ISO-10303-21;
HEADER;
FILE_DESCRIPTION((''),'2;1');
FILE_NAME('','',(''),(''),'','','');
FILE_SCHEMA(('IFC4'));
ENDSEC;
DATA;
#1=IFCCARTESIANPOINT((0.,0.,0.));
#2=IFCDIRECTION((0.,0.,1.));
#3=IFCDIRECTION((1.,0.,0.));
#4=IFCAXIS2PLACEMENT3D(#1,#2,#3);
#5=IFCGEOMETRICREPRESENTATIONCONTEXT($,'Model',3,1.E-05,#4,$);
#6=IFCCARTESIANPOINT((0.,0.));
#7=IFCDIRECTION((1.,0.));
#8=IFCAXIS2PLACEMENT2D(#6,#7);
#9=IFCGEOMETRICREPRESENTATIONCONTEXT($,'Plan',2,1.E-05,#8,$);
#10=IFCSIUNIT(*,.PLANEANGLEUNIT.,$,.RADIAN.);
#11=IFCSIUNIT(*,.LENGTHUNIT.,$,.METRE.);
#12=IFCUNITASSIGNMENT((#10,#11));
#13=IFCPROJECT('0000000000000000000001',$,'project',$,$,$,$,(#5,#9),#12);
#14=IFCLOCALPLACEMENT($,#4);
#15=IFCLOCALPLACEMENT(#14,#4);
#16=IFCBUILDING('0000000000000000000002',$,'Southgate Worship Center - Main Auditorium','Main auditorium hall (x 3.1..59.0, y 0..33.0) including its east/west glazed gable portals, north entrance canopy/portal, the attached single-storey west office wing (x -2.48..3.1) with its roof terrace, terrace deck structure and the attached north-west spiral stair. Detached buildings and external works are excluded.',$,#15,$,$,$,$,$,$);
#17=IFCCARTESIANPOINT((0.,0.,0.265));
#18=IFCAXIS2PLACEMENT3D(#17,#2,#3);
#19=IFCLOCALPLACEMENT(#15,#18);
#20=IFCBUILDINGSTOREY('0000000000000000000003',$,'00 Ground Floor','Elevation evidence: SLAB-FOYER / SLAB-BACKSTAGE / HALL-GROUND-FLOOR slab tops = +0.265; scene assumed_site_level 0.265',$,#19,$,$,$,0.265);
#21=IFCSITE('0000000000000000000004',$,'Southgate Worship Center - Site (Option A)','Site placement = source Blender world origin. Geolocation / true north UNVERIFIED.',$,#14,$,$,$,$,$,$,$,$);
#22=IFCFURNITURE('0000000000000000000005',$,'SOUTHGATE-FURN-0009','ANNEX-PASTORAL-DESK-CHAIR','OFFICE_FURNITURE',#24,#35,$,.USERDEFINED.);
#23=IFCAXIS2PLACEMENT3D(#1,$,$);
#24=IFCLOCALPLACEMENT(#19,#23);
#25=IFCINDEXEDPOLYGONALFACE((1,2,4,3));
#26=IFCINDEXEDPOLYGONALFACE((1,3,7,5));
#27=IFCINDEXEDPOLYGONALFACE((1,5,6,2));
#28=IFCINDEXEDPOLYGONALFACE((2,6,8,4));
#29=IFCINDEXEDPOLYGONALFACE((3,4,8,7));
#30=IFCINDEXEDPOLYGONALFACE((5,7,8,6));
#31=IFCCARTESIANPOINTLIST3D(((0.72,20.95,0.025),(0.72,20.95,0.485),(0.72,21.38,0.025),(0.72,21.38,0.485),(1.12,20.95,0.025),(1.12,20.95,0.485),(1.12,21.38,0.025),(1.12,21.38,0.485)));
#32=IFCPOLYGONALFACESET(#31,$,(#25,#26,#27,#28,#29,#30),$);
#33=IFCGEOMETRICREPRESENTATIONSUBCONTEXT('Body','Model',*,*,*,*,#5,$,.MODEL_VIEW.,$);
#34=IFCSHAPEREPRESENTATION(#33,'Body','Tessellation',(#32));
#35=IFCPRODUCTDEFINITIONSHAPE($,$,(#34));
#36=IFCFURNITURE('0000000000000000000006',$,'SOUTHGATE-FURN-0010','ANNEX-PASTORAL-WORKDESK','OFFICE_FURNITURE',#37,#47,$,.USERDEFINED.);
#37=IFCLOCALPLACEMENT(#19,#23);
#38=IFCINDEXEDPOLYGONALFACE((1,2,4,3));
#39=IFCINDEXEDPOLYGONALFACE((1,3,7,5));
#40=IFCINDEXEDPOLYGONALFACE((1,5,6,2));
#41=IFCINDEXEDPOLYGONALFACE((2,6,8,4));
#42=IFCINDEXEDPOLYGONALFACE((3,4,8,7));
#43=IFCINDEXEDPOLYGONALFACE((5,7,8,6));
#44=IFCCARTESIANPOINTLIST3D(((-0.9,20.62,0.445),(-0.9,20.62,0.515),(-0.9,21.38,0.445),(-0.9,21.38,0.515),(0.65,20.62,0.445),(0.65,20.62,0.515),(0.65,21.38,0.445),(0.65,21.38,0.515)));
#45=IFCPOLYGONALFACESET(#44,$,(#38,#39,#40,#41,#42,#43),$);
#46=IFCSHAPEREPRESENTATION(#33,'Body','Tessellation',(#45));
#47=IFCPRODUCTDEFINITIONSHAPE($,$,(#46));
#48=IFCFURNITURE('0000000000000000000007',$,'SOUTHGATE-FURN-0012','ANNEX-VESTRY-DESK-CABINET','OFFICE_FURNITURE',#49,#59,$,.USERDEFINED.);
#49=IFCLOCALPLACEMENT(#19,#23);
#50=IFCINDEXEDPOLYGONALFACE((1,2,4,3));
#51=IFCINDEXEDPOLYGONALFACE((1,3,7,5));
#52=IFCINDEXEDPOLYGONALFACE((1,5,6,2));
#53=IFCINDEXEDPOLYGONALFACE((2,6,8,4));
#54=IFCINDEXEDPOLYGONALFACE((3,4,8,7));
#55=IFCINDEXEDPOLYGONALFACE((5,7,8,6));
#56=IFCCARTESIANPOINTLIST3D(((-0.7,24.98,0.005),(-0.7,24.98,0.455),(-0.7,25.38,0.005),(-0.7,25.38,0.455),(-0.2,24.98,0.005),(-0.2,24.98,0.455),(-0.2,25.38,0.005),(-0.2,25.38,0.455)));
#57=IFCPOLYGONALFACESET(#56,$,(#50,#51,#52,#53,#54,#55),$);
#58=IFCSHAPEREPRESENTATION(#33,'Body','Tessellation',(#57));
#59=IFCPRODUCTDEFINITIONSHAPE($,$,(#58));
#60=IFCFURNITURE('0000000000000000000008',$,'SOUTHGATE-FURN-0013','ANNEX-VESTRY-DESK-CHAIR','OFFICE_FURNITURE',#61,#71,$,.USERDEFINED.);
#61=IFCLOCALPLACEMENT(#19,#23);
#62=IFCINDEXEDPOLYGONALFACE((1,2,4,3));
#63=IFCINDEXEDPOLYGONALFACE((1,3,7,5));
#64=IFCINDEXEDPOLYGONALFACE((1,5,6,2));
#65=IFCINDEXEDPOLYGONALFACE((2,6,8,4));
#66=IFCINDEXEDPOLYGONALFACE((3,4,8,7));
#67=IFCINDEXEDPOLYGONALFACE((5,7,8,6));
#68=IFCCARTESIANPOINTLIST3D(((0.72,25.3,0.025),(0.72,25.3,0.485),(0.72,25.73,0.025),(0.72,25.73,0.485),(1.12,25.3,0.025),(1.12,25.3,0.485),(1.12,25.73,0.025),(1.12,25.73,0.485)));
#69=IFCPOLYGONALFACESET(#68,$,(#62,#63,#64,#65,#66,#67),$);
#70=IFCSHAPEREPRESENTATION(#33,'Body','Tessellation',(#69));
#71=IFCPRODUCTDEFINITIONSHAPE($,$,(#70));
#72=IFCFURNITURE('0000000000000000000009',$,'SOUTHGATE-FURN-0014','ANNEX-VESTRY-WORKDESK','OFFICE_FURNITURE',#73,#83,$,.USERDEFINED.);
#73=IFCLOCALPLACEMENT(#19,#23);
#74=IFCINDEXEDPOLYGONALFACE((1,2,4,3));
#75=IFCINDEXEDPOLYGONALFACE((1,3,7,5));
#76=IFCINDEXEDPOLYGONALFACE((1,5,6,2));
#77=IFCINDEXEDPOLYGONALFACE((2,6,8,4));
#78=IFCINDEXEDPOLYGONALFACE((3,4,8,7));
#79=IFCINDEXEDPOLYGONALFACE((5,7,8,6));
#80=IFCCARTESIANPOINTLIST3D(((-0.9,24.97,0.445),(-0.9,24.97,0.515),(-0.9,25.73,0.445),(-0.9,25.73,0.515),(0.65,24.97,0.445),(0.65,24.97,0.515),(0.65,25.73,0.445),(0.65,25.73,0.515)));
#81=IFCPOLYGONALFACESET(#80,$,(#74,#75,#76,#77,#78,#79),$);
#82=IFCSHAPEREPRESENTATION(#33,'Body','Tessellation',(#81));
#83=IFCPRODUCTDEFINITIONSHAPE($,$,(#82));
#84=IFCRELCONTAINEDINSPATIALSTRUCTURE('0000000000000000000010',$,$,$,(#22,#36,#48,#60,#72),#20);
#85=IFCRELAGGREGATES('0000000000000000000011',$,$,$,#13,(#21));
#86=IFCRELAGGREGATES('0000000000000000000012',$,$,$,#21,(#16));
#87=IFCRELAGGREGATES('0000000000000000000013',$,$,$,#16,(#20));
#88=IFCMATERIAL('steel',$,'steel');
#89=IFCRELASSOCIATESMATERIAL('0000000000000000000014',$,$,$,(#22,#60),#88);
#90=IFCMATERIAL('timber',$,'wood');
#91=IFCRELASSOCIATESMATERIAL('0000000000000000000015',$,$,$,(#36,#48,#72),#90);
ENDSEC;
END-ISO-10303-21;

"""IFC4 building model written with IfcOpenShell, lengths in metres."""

from ifc_helpers import new_model, si_unit, frame, origin_with_axes, origin_2d, origin_2d_with_axis, place, context, subcontext, project, spatial, rectangle, extrude, material, element, save


model = new_model("IFC4")

# Units and contexts
model_context = context("Model", 3, precision=1e-05, world=origin_with_axes())
plan_context = context("Plan", 2, precision=1e-05, world=origin_2d_with_axis())
body_context = subcontext(model_context, "Body", "Model", "MODEL_VIEW")
ifc_project = project(units=[si_unit("PLANEANGLEUNIT", "RADIAN"), si_unit("LENGTHUNIT", "METRE")], contexts=[model_context, plan_context])

# Site, building, storey
site_placement = place(None, origin_with_axes())
site = spatial("IfcSite", under=ifc_project, at=site_placement, Name="Southgate Worship Center - Site (Option A)", Description="Site placement = source Blender world origin. Geolocation / true north UNVERIFIED.")
building_placement = place(site_placement, origin_with_axes())
building = spatial("IfcBuilding", under=site, at=building_placement, Name="Southgate Worship Center - Main Auditorium", Description="Main auditorium hall (x 3.1..59.0, y 0..33.0) including its east/west glazed gable portals, north entrance canopy/portal, the attached single-storey west office wing (x -2.48..3.1) with its roof terrace, terrace deck structure and the attached north-west spiral stair. Detached buildings and external works are excluded.")
storey_placement = place(building_placement, frame((0.0, 0.0, 0.265), z_axis=(0.0, 0.0, 1.0), x_axis=(1.0, 0.0, 0.0)))
storey = spatial("IfcBuildingStorey", under=building, at=storey_placement, Name="00 Ground Floor", Description="Elevation evidence: SLAB-FOYER / SLAB-BACKSTAGE / HALL-GROUND-FLOOR slab tops = +0.265; scene assumed_site_level 0.265", Elevation=0.265)

# Shared definitions
ifc_material_1 = material(Name="timber", Category="wood")

# Furniture
ifc_material_2 = material(Name="steel", Category="steel")
furniture_1_placement = place(storey_placement, frame((0.72, 20.95, 0.025), z_axis=(0.0, 0.0, 1.0), x_axis=(1.0, 0.0, 0.0)))
element("IfcFurniture", 1, at=furniture_1_placement, inside=storey, material=ifc_material_2, Name="SOUTHGATE-FURN-0009", Description="ANNEX-PASTORAL-DESK-CHAIR", ObjectType="OFFICE_FURNITURE", PredefinedType="USERDEFINED", context=body_context, shape_type="SweptSolid", body=[
    extrude(rectangle(XDim=0.43, YDim=0.4, at=origin_2d()), frame((0.2, 0.215, 0.0), z_axis=(0.0, 0.0, 1.0), x_axis=(0.0, 1.0, 0.0)), (0.0, 0.0, 1.0), 0.46),
])
furniture_2_placement = place(storey_placement, frame((-0.9, 20.62, 0.445), z_axis=(0.0, 0.0, 1.0), x_axis=(1.0, 0.0, 0.0)))
element("IfcFurniture", 2, at=furniture_2_placement, inside=storey, material=ifc_material_1, Name="SOUTHGATE-FURN-0010", Description="ANNEX-PASTORAL-WORKDESK", ObjectType="OFFICE_FURNITURE", PredefinedType="USERDEFINED", context=body_context, shape_type="SweptSolid", body=[
    extrude(rectangle(XDim=0.76, YDim=1.55, at=origin_2d()), frame((0.775, 0.38, 0.0), z_axis=(0.0, 0.0, 1.0), x_axis=(0.0, -1.0, 0.0)), (0.0, 0.0, 1.0), 0.07),
])
furniture_3_placement = place(storey_placement, frame((-0.7, 24.98, 0.005), z_axis=(0.0, 0.0, 1.0), x_axis=(1.0, 0.0, 0.0)))
element("IfcFurniture", 3, at=furniture_3_placement, inside=storey, material=ifc_material_1, Name="SOUTHGATE-FURN-0012", Description="ANNEX-VESTRY-DESK-CABINET", ObjectType="OFFICE_FURNITURE", PredefinedType="USERDEFINED", context=body_context, shape_type="SweptSolid", body=[
    extrude(rectangle(XDim=0.4, YDim=0.5, at=origin_2d()), frame((0.25, 0.2, 0.0), z_axis=(0.0, 0.0, 1.0), x_axis=(0.0, -1.0, 0.0)), (0.0, 0.0, 1.0), 0.45),
])
furniture_4_placement = place(storey_placement, frame((0.72, 25.3, 0.025), z_axis=(0.0, 0.0, 1.0), x_axis=(1.0, 0.0, 0.0)))
element("IfcFurniture", 4, at=furniture_4_placement, inside=storey, material=ifc_material_2, Name="SOUTHGATE-FURN-0013", Description="ANNEX-VESTRY-DESK-CHAIR", ObjectType="OFFICE_FURNITURE", PredefinedType="USERDEFINED", context=body_context, shape_type="SweptSolid", body=[
    extrude(rectangle(XDim=0.43, YDim=0.4, at=origin_2d()), frame((0.2, 0.215, 0.0), z_axis=(0.0, 0.0, 1.0), x_axis=(0.0, 1.0, 0.0)), (0.0, 0.0, 1.0), 0.46),
])
furniture_5_placement = place(storey_placement, frame((-0.9, 24.97, 0.445), z_axis=(0.0, 0.0, 1.0), x_axis=(1.0, 0.0, 0.0)))
element("IfcFurniture", 5, at=furniture_5_placement, inside=storey, material=ifc_material_1, Name="SOUTHGATE-FURN-0014", Description="ANNEX-VESTRY-WORKDESK", ObjectType="OFFICE_FURNITURE", PredefinedType="USERDEFINED", context=body_context, shape_type="SweptSolid", body=[
    extrude(rectangle(XDim=0.76, YDim=1.55, at=origin_2d()), frame((0.775, 0.38, 0.0), z_axis=(0.0, 0.0, 1.0), x_axis=(0.0, -1.0, 0.0)), (0.0, 0.0, 1.0), 0.07),
])

save(model, "model.ifc")
